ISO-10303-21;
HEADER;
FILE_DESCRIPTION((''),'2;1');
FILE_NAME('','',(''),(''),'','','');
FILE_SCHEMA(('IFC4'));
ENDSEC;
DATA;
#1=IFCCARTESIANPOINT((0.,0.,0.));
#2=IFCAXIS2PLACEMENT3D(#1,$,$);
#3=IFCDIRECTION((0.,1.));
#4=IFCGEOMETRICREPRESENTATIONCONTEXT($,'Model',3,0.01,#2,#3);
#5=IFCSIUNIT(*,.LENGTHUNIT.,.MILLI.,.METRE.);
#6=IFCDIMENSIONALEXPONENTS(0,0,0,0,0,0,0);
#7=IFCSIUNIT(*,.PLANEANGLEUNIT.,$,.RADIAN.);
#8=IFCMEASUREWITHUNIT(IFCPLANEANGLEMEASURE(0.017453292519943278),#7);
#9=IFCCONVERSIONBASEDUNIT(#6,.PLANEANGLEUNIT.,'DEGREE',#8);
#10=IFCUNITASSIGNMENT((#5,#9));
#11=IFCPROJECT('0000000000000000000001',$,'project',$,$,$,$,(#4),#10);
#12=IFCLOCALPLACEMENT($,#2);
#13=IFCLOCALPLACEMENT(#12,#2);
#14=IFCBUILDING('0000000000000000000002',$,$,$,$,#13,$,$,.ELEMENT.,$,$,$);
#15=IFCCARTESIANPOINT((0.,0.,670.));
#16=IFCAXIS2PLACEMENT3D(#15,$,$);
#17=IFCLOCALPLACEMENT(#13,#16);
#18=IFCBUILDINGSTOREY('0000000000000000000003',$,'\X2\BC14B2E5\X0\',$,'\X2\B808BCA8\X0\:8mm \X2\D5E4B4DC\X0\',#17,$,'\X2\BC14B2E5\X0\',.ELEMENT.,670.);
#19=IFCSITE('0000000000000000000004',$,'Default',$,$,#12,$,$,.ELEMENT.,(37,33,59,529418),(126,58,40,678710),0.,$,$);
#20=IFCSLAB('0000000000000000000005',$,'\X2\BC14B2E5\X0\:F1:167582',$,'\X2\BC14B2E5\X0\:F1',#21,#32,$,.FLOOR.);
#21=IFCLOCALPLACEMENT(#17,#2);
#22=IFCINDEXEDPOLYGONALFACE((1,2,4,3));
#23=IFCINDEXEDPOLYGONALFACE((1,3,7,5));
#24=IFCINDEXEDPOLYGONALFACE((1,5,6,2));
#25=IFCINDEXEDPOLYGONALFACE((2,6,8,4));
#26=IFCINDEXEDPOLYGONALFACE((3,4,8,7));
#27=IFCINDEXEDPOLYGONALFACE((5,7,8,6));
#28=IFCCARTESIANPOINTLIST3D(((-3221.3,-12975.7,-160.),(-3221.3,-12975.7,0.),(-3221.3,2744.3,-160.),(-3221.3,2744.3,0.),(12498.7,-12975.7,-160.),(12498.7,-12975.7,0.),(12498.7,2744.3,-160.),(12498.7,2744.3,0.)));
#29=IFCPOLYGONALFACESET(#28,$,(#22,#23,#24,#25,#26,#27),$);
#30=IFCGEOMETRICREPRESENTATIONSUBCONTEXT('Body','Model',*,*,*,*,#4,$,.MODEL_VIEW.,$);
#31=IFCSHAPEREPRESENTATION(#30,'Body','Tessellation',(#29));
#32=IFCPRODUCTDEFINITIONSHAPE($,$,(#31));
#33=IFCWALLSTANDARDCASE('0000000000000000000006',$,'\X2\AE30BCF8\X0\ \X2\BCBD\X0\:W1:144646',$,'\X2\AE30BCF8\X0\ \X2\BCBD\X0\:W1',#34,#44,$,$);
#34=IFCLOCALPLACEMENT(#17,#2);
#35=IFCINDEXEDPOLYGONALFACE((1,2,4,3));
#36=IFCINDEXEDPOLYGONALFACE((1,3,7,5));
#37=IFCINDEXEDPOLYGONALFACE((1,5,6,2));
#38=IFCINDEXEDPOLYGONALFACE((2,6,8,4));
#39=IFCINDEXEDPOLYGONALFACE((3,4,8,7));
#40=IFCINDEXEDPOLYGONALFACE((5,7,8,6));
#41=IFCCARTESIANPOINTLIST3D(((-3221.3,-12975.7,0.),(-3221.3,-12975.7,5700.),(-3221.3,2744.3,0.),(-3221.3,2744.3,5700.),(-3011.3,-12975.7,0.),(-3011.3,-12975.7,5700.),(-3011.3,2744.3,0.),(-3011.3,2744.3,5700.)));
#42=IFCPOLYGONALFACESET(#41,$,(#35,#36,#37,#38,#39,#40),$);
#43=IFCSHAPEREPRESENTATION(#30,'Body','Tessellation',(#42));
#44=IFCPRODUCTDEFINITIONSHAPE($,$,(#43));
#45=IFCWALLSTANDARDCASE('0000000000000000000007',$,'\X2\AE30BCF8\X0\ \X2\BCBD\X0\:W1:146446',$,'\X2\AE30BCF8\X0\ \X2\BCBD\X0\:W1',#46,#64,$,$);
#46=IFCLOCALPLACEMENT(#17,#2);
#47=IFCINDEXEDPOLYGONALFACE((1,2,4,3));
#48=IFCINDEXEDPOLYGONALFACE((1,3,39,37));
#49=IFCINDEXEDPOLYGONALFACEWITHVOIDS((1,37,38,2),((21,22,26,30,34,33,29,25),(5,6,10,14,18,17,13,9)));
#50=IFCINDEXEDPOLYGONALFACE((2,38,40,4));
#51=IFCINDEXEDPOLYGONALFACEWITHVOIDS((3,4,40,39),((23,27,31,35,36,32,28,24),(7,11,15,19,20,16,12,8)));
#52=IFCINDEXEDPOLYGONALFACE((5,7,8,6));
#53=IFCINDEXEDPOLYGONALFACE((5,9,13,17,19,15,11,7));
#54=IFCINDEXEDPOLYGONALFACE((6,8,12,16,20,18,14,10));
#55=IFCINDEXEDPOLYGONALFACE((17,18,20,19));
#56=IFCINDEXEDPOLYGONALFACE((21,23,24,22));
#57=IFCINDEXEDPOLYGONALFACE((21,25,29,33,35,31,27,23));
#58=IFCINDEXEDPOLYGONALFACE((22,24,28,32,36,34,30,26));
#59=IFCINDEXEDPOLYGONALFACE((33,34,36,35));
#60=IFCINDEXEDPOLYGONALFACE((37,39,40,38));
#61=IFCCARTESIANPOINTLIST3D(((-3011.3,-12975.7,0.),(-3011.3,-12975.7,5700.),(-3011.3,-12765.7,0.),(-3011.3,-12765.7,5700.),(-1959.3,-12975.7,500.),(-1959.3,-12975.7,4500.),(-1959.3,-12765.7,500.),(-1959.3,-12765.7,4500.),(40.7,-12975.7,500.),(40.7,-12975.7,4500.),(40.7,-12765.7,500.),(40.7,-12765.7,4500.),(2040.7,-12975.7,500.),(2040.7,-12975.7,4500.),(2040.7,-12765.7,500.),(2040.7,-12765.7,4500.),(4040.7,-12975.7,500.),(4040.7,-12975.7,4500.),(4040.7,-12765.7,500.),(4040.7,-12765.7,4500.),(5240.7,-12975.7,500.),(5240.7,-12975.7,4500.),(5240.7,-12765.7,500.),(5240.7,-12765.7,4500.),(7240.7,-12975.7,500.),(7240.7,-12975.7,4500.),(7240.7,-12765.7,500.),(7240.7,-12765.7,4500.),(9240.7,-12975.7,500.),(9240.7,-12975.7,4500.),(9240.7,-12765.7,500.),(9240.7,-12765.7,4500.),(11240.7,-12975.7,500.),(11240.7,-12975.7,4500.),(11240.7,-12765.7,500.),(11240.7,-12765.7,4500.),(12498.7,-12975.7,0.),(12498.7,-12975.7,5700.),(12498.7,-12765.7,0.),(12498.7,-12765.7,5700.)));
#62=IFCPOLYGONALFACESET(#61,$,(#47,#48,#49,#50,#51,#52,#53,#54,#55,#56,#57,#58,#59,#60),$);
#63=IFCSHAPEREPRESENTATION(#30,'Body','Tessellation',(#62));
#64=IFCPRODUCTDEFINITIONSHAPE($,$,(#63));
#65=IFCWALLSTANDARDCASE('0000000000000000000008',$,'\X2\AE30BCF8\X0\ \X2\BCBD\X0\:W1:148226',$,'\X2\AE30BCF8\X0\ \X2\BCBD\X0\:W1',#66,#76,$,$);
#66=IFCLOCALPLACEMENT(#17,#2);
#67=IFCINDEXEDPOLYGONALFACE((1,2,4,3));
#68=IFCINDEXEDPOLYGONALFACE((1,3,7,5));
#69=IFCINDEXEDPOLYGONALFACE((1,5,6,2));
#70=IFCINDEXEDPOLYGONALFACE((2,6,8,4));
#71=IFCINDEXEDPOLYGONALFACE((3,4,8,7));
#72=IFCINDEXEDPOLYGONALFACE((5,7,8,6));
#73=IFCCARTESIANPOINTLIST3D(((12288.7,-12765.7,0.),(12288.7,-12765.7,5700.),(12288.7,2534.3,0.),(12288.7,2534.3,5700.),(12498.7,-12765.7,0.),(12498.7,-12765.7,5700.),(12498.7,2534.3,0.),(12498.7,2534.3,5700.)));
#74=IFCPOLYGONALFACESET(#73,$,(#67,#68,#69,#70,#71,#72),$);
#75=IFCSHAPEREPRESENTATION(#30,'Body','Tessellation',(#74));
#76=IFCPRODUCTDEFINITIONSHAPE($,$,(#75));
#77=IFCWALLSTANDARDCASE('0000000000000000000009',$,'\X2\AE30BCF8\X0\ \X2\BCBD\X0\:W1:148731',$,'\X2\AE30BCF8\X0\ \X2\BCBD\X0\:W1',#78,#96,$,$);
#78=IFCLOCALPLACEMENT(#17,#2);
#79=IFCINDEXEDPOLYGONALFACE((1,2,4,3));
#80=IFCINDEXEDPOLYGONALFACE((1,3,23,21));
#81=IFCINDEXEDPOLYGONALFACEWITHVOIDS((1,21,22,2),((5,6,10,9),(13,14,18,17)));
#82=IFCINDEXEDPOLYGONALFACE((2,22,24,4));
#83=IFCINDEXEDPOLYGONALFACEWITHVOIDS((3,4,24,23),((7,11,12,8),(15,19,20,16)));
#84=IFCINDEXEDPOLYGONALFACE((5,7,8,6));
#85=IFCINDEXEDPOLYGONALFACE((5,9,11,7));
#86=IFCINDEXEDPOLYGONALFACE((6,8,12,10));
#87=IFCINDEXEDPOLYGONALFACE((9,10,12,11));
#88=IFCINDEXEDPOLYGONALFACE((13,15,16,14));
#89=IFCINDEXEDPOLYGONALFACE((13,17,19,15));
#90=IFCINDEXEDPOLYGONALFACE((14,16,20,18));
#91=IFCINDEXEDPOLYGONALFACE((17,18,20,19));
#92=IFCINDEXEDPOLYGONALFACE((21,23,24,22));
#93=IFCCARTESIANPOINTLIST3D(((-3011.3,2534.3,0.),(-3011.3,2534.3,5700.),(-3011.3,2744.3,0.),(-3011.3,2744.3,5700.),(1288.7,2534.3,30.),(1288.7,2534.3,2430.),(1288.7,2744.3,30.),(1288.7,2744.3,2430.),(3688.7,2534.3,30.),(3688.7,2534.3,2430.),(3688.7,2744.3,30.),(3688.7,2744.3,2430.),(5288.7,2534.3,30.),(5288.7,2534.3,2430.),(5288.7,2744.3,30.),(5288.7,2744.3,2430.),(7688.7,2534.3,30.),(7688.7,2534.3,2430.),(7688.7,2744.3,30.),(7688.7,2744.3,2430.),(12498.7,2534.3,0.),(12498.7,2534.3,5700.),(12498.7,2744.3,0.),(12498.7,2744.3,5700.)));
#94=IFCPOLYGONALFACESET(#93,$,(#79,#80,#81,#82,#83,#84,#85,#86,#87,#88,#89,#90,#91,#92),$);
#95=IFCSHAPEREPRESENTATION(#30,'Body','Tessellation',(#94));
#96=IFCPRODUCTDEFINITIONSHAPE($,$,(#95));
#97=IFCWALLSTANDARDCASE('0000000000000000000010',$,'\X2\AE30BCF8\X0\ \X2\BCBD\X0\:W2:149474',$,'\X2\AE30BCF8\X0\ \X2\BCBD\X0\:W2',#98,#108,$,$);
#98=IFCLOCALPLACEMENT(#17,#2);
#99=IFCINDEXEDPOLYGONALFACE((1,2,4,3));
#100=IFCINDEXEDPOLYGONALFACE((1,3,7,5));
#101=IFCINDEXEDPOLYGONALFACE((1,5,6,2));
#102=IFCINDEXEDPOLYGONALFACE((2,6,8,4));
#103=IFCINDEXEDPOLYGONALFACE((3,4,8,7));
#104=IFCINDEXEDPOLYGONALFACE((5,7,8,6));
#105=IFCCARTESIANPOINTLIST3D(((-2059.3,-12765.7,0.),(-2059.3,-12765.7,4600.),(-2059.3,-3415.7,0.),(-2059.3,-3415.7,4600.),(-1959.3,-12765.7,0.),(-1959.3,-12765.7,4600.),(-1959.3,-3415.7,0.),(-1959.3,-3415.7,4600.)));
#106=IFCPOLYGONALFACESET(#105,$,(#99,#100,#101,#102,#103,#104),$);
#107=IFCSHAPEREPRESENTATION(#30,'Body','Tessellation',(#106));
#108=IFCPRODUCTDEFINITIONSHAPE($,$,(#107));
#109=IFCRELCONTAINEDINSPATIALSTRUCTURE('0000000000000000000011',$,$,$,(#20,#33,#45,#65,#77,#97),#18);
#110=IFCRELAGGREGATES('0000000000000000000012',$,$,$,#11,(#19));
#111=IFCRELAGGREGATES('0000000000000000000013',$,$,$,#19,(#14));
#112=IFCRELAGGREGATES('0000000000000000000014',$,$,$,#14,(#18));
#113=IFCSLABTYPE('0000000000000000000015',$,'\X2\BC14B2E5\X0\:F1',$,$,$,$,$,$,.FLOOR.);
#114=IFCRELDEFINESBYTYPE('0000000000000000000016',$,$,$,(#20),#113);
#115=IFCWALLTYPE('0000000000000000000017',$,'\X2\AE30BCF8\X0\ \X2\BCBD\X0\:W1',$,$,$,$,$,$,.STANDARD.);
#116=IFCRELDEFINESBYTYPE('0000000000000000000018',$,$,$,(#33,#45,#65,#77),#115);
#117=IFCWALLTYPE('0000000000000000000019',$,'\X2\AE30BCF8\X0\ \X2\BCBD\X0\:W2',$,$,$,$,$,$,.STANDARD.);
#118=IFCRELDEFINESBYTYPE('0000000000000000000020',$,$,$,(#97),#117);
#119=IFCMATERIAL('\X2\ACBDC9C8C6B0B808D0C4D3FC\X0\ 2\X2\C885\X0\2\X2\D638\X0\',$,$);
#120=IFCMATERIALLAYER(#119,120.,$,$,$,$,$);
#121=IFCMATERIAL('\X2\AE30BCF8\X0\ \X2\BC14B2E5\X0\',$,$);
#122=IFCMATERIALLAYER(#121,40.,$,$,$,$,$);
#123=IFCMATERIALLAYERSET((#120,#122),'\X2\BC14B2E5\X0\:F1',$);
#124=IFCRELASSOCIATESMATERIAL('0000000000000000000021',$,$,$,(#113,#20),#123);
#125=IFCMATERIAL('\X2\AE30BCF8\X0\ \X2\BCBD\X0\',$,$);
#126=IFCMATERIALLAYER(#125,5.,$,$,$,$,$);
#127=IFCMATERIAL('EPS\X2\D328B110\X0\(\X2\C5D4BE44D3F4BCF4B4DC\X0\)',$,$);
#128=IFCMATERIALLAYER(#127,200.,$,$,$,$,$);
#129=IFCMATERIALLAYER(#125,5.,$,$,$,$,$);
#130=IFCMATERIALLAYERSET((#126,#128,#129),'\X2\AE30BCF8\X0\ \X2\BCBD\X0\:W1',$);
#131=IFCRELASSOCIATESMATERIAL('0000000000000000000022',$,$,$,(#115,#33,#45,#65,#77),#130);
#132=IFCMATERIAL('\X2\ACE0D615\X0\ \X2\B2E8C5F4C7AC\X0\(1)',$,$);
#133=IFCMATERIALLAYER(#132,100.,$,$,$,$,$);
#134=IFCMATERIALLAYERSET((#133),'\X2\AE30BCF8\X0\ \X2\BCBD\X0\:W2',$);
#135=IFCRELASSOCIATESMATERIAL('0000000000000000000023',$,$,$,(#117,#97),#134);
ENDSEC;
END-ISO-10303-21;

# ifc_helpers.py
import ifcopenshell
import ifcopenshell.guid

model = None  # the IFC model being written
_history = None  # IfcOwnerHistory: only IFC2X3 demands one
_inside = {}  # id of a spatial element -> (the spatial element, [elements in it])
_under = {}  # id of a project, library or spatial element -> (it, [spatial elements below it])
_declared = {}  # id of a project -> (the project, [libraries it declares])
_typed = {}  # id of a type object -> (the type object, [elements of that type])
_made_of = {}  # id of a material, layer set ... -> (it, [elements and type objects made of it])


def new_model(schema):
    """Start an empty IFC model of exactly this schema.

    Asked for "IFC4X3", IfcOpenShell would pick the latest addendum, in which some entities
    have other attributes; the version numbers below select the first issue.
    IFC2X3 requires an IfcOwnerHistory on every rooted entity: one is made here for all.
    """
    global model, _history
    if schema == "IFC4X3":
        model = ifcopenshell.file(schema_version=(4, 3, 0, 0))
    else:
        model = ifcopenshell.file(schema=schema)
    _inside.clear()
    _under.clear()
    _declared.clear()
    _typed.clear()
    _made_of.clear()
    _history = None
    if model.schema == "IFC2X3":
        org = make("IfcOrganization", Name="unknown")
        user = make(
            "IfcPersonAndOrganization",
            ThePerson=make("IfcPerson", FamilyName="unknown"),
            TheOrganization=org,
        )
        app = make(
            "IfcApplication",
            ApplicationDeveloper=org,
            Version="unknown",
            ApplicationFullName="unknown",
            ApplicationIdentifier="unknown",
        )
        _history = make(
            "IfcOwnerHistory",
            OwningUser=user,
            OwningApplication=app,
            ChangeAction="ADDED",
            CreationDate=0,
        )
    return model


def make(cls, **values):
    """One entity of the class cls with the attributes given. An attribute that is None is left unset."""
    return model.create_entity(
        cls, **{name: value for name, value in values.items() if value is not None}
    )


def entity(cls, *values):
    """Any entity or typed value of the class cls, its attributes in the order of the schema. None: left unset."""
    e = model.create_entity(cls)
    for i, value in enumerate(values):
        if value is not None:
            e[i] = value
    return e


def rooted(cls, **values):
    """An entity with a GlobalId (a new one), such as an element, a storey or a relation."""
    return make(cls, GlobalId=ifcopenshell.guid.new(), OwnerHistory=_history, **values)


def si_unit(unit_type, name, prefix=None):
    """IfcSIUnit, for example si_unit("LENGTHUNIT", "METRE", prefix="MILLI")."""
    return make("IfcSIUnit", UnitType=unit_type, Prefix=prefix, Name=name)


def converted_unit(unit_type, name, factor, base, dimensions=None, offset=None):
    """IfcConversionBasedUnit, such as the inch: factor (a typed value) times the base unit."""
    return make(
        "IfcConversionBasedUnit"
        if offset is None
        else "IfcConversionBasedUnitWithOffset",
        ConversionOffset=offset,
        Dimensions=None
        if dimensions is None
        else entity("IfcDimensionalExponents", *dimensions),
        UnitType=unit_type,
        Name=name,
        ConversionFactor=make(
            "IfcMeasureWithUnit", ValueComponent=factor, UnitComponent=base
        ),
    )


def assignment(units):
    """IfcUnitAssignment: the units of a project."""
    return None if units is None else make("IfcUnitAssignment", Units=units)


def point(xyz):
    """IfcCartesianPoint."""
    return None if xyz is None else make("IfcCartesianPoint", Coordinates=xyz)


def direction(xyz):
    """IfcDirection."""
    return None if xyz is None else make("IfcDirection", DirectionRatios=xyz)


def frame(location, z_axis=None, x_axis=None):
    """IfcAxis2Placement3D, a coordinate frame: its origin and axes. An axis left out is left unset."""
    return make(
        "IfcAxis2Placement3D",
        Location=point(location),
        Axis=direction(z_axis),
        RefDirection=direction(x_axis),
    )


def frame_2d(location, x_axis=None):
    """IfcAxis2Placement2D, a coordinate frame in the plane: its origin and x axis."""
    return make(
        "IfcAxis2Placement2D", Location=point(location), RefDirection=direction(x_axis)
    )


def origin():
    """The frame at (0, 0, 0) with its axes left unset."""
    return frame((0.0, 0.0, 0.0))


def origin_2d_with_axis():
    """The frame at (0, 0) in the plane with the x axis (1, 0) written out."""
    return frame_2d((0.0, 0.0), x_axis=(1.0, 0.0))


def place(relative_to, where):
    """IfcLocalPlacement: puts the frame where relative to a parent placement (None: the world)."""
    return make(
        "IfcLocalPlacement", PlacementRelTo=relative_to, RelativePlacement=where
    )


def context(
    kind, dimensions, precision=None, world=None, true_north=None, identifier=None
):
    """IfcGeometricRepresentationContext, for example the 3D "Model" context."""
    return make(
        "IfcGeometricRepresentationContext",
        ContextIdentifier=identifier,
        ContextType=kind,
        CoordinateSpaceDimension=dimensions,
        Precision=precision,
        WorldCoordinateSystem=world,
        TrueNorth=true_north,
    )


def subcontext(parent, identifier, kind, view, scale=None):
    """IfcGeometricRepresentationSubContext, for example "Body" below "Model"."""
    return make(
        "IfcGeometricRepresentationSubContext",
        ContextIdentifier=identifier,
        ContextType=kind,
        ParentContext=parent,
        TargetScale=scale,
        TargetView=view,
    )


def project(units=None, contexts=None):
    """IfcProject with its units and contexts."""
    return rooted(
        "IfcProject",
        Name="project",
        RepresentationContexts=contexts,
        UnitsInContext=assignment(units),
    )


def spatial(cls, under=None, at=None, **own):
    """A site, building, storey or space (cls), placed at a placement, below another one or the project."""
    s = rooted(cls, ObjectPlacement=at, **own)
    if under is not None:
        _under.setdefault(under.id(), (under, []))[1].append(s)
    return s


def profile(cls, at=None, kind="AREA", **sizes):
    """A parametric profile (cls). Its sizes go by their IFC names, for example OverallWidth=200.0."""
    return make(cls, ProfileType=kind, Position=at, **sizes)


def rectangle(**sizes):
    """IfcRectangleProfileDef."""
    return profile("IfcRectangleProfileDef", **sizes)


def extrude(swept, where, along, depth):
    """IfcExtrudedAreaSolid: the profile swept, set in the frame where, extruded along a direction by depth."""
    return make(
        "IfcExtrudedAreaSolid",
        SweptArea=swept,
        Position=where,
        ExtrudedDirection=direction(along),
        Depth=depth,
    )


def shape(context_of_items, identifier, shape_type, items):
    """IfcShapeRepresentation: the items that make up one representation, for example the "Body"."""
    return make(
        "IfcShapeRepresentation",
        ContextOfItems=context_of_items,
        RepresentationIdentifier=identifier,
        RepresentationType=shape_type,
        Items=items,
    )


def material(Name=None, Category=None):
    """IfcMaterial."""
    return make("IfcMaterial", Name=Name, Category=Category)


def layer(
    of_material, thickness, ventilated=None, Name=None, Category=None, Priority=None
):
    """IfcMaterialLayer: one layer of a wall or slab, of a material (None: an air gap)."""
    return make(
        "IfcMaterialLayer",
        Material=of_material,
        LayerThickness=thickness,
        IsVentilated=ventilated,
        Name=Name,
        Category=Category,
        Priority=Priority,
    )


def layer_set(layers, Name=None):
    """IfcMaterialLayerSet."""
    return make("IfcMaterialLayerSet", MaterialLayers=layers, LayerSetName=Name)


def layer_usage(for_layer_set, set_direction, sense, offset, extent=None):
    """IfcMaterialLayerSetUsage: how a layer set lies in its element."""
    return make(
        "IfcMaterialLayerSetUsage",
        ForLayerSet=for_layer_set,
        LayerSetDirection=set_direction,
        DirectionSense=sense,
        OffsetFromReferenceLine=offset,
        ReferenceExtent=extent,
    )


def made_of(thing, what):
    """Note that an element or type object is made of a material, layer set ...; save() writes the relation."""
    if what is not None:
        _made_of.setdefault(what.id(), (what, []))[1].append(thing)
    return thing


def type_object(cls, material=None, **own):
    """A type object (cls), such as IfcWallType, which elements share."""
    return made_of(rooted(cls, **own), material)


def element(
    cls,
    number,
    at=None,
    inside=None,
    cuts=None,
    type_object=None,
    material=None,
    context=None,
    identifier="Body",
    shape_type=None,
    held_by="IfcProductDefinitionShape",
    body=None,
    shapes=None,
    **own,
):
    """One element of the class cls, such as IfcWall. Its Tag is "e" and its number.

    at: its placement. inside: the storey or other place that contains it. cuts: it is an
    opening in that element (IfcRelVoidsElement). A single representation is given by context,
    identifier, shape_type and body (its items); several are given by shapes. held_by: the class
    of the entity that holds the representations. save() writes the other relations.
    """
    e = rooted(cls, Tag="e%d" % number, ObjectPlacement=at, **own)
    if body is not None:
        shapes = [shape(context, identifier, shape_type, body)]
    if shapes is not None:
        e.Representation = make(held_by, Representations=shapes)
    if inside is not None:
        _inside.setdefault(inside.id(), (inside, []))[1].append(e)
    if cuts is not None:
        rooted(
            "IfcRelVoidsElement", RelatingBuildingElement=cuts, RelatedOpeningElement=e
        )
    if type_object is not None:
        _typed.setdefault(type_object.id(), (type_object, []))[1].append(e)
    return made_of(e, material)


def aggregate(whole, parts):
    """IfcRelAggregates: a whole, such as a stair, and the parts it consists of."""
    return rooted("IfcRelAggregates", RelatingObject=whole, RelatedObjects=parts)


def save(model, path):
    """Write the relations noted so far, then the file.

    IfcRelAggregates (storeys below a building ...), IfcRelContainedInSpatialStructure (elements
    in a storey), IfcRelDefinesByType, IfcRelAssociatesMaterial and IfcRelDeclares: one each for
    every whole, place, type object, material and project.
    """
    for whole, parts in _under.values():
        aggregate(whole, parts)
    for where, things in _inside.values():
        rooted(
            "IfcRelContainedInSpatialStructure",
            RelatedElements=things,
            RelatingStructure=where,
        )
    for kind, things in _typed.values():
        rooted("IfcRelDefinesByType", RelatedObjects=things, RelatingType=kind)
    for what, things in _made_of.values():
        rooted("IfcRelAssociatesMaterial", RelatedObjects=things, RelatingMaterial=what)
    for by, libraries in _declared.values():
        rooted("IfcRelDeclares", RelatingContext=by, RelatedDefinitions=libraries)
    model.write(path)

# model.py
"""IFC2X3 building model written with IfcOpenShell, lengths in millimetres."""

from ifc_helpers import new_model, entity, si_unit, converted_unit, direction, frame, frame_2d, origin, origin_2d_with_axis, place, context, subcontext, project, spatial, rectangle, extrude, material, layer, layer_set, layer_usage, type_object, element, save


model = new_model("IFC2X3")

# Units and contexts
model_context = context("Model", 3, precision=0.01, world=origin(), true_north=direction((0.0, 1.0)))
body_context = subcontext(model_context, "Body", "Model", "MODEL_VIEW")
ifc_project = project(units=[si_unit("LENGTHUNIT", "METRE", prefix="MILLI"), converted_unit("PLANEANGLEUNIT", "DEGREE", entity("IfcPlaneAngleMeasure", 0.017453292519943278), si_unit("PLANEANGLEUNIT", "RADIAN"), dimensions=[0, 0, 0, 0, 0, 0, 0])], contexts=[model_context])

# Site, building, storey
site_placement = place(None, origin())
site = spatial("IfcSite", under=ifc_project, at=site_placement, Name="Default", CompositionType="ELEMENT", RefLatitude=(37, 33, 59, 529418), RefLongitude=(126, 58, 40, 678710), RefElevation=0.0)
building_placement = place(site_placement, origin())
building = spatial("IfcBuilding", under=site, at=building_placement, CompositionType="ELEMENT")
storey_placement = place(building_placement, frame((0.0, 0.0, 670.0)))
storey = spatial("IfcBuildingStorey", under=building, at=storey_placement, Name="바닥", ObjectType="레벨:8mm 헤드", LongName="바닥", CompositionType="ELEMENT", Elevation=670.0)

# Slab
ifc_material_1 = material(Name="경질우레탄폼 2종2호")
ifc_layer_1 = layer(ifc_material_1, 120.0)
ifc_material_2 = material(Name="기본 바닥")
ifc_layer_2 = layer(ifc_material_2, 40.0)
ifc_layer_set_1 = layer_set([ifc_layer_1, ifc_layer_2], Name="바닥:F1")
ifc_layer_usage_1 = layer_usage(ifc_layer_set_1, "AXIS3", "POSITIVE", 0.0)
slab_type = type_object("IfcSlabType", Name="바닥:F1", PredefinedType="FLOOR", material=ifc_layer_set_1)
slab_placement = place(storey_placement, origin())
element("IfcSlab", 1, at=slab_placement, inside=storey, type_object=slab_type, material=ifc_layer_usage_1, Name="바닥:F1:167582", ObjectType="바닥:F1", PredefinedType="FLOOR", context=body_context, shape_type="SweptSolid", body=[
    extrude(rectangle(XDim=15720.0, YDim=15720.0, at=origin_2d_with_axis()), frame((4638.7, -5115.7, 0.0), z_axis=(0.0, 0.0, -1.0), x_axis=(0.0, 1.0, 0.0)), (0.0, 0.0, 1.0), 160.0),
])

# Wall
ifc_material_3 = material(Name="기본 벽")
ifc_layer_3 = layer(ifc_material_3, 5.0)
ifc_material_4 = material(Name="EPS패널(엔비폴보드)")
ifc_layer_4 = layer(ifc_material_4, 200.0)
ifc_layer_5 = layer(ifc_material_3, 5.0)
ifc_layer_set_2 = layer_set([ifc_layer_3, ifc_layer_4, ifc_layer_5], Name="기본 벽:W1")
ifc_layer_usage_2 = layer_usage(ifc_layer_set_2, "AXIS2", "NEGATIVE", 105.0)
wall_type_1 = type_object("IfcWallType", Name="기본 벽:W1", PredefinedType="STANDARD", material=ifc_layer_set_2)
wall_1_placement = place(storey_placement, frame((-3116.3, -12975.7, 0.0), z_axis=(0.0, 0.0, 1.0), x_axis=(0.0, 1.0, 0.0)))
element("IfcWallStandardCase", 2, at=wall_1_placement, inside=storey, type_object=wall_type_1, material=ifc_layer_usage_2, Name="기본 벽:W1:144646", ObjectType="기본 벽:W1", context=body_context, shape_type="SweptSolid", body=[
    extrude(rectangle(XDim=15720.0, YDim=210.0, at=frame_2d((7860.0, 0.0), x_axis=(-1.0, 0.0))), origin(), (0.0, 0.0, 1.0), 5700.0),
])

# Wall, openings
ifc_layer_usage_3 = layer_usage(ifc_layer_set_2, "AXIS2", "NEGATIVE", 105.0)
wall_2_placement = place(storey_placement, frame((12498.7, -12870.7, 0.0), z_axis=(0.0, 0.0, 1.0), x_axis=(-1.0, 0.0, 0.0)))
wall_2 = element("IfcWallStandardCase", 3, at=wall_2_placement, inside=storey, type_object=wall_type_1, material=ifc_layer_usage_3, Name="기본 벽:W1:146446", ObjectType="기본 벽:W1", context=body_context, shape_type="SweptSolid", body=[
    extrude(rectangle(XDim=15510.0, YDim=210.0, at=frame_2d((7755.0, 0.0), x_axis=(-1.0, 0.0))), origin(), (0.0, 0.0, 1.0), 5700.0),
])
opening_1_placement = place(wall_2_placement, frame((12458.0, -105.0, 500.0)))
element("IfcOpeningElement", 4, at=opening_1_placement, cuts=wall_2, ObjectType="Opening", context=body_context, shape_type="SweptSolid", body=[
    extrude(rectangle(XDim=4000.0, YDim=2000.0, at=frame_2d((2000.0, 1000.0), x_axis=(1.0, 0.0))), frame((0.0, 0.0, 0.0), z_axis=(0.0, 1.0, 0.0), x_axis=(0.0, 0.0, 1.0)), (0.0, 0.0, 1.0), 210.0),
])
opening_2_placement = place(wall_2_placement, frame((8458.0, -105.0, 500.0)))
element("IfcOpeningElement", 5, at=opening_2_placement, cuts=wall_2, ObjectType="Opening", context=body_context, shape_type="SweptSolid", body=[
    extrude(rectangle(XDim=4000.0, YDim=2000.0, at=frame_2d((2000.0, 1000.0), x_axis=(1.0, 0.0))), frame((0.0, 0.0, 0.0), z_axis=(0.0, 1.0, 0.0), x_axis=(0.0, 0.0, 1.0)), (0.0, 0.0, 1.0), 210.0),
])
opening_3_placement = place(wall_2_placement, frame((5258.0, -105.0, 500.0)))
element("IfcOpeningElement", 6, at=opening_3_placement, cuts=wall_2, ObjectType="Opening", context=body_context, shape_type="SweptSolid", body=[
    extrude(rectangle(XDim=4000.0, YDim=2000.0, at=frame_2d((2000.0, 1000.0), x_axis=(1.0, 0.0))), frame((0.0, 0.0, 0.0), z_axis=(0.0, 1.0, 0.0), x_axis=(0.0, 0.0, 1.0)), (0.0, 0.0, 1.0), 210.0),
])
opening_4_placement = place(wall_2_placement, frame((3258.0, -105.0, 500.0)))
element("IfcOpeningElement", 7, at=opening_4_placement, cuts=wall_2, ObjectType="Opening", context=body_context, shape_type="SweptSolid", body=[
    extrude(rectangle(XDim=4000.0, YDim=2000.0, at=frame_2d((2000.0, 1000.0), x_axis=(1.0, 0.0))), frame((0.0, 0.0, 0.0), z_axis=(0.0, 1.0, 0.0), x_axis=(0.0, 0.0, 1.0)), (0.0, 0.0, 1.0), 210.0),
])
opening_5_placement = place(wall_2_placement, frame((1258.0, -105.0, 500.0)))
element("IfcOpeningElement", 8, at=opening_5_placement, cuts=wall_2, ObjectType="Opening", context=body_context, shape_type="SweptSolid", body=[
    extrude(rectangle(XDim=4000.0, YDim=2000.0, at=frame_2d((2000.0, 1000.0), x_axis=(1.0, 0.0))), frame((0.0, 0.0, 0.0), z_axis=(0.0, 1.0, 0.0), x_axis=(0.0, 0.0, 1.0)), (0.0, 0.0, 1.0), 210.0),
])
opening_6_placement = place(wall_2_placement, frame((10458.0, -105.0, 500.0)))
element("IfcOpeningElement", 9, at=opening_6_placement, cuts=wall_2, ObjectType="Opening", context=body_context, shape_type="SweptSolid", body=[
    extrude(rectangle(XDim=4000.0, YDim=2000.0, at=frame_2d((2000.0, 1000.0), x_axis=(1.0, 0.0))), frame((0.0, 0.0, 0.0), z_axis=(0.0, 1.0, 0.0), x_axis=(0.0, 0.0, 1.0)), (0.0, 0.0, 1.0), 210.0),
])

# Wall
ifc_layer_usage_4 = layer_usage(ifc_layer_set_2, "AXIS2", "NEGATIVE", 105.0)
wall_3_placement = place(storey_placement, frame((12393.7, 2534.3, 0.0), z_axis=(0.0, 0.0, 1.0), x_axis=(0.0, -1.0, 0.0)))
element("IfcWallStandardCase", 10, at=wall_3_placement, inside=storey, type_object=wall_type_1, material=ifc_layer_usage_4, Name="기본 벽:W1:148226", ObjectType="기본 벽:W1", context=body_context, shape_type="SweptSolid", body=[
    extrude(rectangle(XDim=15300.0, YDim=210.0, at=frame_2d((7650.0, 0.0), x_axis=(-1.0, 0.0))), origin(), (0.0, 0.0, 1.0), 5700.0),
])

# Wall, openings
ifc_layer_usage_5 = layer_usage(ifc_layer_set_2, "AXIS2", "NEGATIVE", 105.0)
wall_4_placement = place(storey_placement, frame((-3011.3, 2639.3, 0.0)))
wall_4 = element("IfcWallStandardCase", 11, at=wall_4_placement, inside=storey, type_object=wall_type_1, material=ifc_layer_usage_5, Name="기본 벽:W1:148731", ObjectType="기본 벽:W1", context=body_context, shape_type="SweptSolid", body=[
    extrude(rectangle(XDim=15510.0, YDim=210.0, at=frame_2d((7755.0, 0.0), x_axis=(-1.0, 0.0))), origin(), (0.0, 0.0, 1.0), 5700.0),
])
opening_7_placement = place(wall_4_placement, frame((8300.0, -105.0, 30.0)))
element("IfcOpeningElement", 12, at=opening_7_placement, cuts=wall_4, ObjectType="Opening", context=body_context, shape_type="SweptSolid", body=[
    extrude(rectangle(XDim=2400.0, YDim=2400.0, at=frame_2d((1200.0, 1200.0), x_axis=(1.0, 0.0))), frame((0.0, 0.0, 0.0), z_axis=(0.0, 1.0, 0.0), x_axis=(0.0, 0.0, 1.0)), (0.0, 0.0, 1.0), 210.0),
])
opening_8_placement = place(wall_4_placement, frame((4300.0, -105.0, 30.0)))
element("IfcOpeningElement", 13, at=opening_8_placement, cuts=wall_4, ObjectType="Opening", context=body_context, shape_type="SweptSolid", body=[
    extrude(rectangle(XDim=2400.0, YDim=2400.0, at=frame_2d((1200.0, 1200.0), x_axis=(1.0, 0.0))), frame((0.0, 0.0, 0.0), z_axis=(0.0, 1.0, 0.0), x_axis=(0.0, 0.0, 1.0)), (0.0, 0.0, 1.0), 210.0),
])

# Wall
ifc_material_5 = material(Name="고형 단열재(1)")
ifc_layer_6 = layer(ifc_material_5, 100.0)
ifc_layer_set_3 = layer_set([ifc_layer_6], Name="기본 벽:W2")
ifc_layer_usage_6 = layer_usage(ifc_layer_set_3, "AXIS2", "NEGATIVE", 50.0)
wall_type_2 = type_object("IfcWallType", Name="기본 벽:W2", PredefinedType="STANDARD", material=ifc_layer_set_3)
wall_5_placement = place(storey_placement, frame((-2009.3, -12765.7, 0.0), z_axis=(0.0, 0.0, 1.0), x_axis=(0.0, 1.0, 0.0)))
element("IfcWallStandardCase", 14, at=wall_5_placement, inside=storey, type_object=wall_type_2, material=ifc_layer_usage_6, Name="기본 벽:W2:149474", ObjectType="기본 벽:W2", context=body_context, shape_type="SweptSolid", body=[
    extrude(rectangle(XDim=9350.0, YDim=100.0, at=frame_2d((4675.0, 0.0), x_axis=(-1.0, 0.0))), origin(), (0.0, 0.0, 1.0), 4600.0),
])

save(model, "model.ifc")
